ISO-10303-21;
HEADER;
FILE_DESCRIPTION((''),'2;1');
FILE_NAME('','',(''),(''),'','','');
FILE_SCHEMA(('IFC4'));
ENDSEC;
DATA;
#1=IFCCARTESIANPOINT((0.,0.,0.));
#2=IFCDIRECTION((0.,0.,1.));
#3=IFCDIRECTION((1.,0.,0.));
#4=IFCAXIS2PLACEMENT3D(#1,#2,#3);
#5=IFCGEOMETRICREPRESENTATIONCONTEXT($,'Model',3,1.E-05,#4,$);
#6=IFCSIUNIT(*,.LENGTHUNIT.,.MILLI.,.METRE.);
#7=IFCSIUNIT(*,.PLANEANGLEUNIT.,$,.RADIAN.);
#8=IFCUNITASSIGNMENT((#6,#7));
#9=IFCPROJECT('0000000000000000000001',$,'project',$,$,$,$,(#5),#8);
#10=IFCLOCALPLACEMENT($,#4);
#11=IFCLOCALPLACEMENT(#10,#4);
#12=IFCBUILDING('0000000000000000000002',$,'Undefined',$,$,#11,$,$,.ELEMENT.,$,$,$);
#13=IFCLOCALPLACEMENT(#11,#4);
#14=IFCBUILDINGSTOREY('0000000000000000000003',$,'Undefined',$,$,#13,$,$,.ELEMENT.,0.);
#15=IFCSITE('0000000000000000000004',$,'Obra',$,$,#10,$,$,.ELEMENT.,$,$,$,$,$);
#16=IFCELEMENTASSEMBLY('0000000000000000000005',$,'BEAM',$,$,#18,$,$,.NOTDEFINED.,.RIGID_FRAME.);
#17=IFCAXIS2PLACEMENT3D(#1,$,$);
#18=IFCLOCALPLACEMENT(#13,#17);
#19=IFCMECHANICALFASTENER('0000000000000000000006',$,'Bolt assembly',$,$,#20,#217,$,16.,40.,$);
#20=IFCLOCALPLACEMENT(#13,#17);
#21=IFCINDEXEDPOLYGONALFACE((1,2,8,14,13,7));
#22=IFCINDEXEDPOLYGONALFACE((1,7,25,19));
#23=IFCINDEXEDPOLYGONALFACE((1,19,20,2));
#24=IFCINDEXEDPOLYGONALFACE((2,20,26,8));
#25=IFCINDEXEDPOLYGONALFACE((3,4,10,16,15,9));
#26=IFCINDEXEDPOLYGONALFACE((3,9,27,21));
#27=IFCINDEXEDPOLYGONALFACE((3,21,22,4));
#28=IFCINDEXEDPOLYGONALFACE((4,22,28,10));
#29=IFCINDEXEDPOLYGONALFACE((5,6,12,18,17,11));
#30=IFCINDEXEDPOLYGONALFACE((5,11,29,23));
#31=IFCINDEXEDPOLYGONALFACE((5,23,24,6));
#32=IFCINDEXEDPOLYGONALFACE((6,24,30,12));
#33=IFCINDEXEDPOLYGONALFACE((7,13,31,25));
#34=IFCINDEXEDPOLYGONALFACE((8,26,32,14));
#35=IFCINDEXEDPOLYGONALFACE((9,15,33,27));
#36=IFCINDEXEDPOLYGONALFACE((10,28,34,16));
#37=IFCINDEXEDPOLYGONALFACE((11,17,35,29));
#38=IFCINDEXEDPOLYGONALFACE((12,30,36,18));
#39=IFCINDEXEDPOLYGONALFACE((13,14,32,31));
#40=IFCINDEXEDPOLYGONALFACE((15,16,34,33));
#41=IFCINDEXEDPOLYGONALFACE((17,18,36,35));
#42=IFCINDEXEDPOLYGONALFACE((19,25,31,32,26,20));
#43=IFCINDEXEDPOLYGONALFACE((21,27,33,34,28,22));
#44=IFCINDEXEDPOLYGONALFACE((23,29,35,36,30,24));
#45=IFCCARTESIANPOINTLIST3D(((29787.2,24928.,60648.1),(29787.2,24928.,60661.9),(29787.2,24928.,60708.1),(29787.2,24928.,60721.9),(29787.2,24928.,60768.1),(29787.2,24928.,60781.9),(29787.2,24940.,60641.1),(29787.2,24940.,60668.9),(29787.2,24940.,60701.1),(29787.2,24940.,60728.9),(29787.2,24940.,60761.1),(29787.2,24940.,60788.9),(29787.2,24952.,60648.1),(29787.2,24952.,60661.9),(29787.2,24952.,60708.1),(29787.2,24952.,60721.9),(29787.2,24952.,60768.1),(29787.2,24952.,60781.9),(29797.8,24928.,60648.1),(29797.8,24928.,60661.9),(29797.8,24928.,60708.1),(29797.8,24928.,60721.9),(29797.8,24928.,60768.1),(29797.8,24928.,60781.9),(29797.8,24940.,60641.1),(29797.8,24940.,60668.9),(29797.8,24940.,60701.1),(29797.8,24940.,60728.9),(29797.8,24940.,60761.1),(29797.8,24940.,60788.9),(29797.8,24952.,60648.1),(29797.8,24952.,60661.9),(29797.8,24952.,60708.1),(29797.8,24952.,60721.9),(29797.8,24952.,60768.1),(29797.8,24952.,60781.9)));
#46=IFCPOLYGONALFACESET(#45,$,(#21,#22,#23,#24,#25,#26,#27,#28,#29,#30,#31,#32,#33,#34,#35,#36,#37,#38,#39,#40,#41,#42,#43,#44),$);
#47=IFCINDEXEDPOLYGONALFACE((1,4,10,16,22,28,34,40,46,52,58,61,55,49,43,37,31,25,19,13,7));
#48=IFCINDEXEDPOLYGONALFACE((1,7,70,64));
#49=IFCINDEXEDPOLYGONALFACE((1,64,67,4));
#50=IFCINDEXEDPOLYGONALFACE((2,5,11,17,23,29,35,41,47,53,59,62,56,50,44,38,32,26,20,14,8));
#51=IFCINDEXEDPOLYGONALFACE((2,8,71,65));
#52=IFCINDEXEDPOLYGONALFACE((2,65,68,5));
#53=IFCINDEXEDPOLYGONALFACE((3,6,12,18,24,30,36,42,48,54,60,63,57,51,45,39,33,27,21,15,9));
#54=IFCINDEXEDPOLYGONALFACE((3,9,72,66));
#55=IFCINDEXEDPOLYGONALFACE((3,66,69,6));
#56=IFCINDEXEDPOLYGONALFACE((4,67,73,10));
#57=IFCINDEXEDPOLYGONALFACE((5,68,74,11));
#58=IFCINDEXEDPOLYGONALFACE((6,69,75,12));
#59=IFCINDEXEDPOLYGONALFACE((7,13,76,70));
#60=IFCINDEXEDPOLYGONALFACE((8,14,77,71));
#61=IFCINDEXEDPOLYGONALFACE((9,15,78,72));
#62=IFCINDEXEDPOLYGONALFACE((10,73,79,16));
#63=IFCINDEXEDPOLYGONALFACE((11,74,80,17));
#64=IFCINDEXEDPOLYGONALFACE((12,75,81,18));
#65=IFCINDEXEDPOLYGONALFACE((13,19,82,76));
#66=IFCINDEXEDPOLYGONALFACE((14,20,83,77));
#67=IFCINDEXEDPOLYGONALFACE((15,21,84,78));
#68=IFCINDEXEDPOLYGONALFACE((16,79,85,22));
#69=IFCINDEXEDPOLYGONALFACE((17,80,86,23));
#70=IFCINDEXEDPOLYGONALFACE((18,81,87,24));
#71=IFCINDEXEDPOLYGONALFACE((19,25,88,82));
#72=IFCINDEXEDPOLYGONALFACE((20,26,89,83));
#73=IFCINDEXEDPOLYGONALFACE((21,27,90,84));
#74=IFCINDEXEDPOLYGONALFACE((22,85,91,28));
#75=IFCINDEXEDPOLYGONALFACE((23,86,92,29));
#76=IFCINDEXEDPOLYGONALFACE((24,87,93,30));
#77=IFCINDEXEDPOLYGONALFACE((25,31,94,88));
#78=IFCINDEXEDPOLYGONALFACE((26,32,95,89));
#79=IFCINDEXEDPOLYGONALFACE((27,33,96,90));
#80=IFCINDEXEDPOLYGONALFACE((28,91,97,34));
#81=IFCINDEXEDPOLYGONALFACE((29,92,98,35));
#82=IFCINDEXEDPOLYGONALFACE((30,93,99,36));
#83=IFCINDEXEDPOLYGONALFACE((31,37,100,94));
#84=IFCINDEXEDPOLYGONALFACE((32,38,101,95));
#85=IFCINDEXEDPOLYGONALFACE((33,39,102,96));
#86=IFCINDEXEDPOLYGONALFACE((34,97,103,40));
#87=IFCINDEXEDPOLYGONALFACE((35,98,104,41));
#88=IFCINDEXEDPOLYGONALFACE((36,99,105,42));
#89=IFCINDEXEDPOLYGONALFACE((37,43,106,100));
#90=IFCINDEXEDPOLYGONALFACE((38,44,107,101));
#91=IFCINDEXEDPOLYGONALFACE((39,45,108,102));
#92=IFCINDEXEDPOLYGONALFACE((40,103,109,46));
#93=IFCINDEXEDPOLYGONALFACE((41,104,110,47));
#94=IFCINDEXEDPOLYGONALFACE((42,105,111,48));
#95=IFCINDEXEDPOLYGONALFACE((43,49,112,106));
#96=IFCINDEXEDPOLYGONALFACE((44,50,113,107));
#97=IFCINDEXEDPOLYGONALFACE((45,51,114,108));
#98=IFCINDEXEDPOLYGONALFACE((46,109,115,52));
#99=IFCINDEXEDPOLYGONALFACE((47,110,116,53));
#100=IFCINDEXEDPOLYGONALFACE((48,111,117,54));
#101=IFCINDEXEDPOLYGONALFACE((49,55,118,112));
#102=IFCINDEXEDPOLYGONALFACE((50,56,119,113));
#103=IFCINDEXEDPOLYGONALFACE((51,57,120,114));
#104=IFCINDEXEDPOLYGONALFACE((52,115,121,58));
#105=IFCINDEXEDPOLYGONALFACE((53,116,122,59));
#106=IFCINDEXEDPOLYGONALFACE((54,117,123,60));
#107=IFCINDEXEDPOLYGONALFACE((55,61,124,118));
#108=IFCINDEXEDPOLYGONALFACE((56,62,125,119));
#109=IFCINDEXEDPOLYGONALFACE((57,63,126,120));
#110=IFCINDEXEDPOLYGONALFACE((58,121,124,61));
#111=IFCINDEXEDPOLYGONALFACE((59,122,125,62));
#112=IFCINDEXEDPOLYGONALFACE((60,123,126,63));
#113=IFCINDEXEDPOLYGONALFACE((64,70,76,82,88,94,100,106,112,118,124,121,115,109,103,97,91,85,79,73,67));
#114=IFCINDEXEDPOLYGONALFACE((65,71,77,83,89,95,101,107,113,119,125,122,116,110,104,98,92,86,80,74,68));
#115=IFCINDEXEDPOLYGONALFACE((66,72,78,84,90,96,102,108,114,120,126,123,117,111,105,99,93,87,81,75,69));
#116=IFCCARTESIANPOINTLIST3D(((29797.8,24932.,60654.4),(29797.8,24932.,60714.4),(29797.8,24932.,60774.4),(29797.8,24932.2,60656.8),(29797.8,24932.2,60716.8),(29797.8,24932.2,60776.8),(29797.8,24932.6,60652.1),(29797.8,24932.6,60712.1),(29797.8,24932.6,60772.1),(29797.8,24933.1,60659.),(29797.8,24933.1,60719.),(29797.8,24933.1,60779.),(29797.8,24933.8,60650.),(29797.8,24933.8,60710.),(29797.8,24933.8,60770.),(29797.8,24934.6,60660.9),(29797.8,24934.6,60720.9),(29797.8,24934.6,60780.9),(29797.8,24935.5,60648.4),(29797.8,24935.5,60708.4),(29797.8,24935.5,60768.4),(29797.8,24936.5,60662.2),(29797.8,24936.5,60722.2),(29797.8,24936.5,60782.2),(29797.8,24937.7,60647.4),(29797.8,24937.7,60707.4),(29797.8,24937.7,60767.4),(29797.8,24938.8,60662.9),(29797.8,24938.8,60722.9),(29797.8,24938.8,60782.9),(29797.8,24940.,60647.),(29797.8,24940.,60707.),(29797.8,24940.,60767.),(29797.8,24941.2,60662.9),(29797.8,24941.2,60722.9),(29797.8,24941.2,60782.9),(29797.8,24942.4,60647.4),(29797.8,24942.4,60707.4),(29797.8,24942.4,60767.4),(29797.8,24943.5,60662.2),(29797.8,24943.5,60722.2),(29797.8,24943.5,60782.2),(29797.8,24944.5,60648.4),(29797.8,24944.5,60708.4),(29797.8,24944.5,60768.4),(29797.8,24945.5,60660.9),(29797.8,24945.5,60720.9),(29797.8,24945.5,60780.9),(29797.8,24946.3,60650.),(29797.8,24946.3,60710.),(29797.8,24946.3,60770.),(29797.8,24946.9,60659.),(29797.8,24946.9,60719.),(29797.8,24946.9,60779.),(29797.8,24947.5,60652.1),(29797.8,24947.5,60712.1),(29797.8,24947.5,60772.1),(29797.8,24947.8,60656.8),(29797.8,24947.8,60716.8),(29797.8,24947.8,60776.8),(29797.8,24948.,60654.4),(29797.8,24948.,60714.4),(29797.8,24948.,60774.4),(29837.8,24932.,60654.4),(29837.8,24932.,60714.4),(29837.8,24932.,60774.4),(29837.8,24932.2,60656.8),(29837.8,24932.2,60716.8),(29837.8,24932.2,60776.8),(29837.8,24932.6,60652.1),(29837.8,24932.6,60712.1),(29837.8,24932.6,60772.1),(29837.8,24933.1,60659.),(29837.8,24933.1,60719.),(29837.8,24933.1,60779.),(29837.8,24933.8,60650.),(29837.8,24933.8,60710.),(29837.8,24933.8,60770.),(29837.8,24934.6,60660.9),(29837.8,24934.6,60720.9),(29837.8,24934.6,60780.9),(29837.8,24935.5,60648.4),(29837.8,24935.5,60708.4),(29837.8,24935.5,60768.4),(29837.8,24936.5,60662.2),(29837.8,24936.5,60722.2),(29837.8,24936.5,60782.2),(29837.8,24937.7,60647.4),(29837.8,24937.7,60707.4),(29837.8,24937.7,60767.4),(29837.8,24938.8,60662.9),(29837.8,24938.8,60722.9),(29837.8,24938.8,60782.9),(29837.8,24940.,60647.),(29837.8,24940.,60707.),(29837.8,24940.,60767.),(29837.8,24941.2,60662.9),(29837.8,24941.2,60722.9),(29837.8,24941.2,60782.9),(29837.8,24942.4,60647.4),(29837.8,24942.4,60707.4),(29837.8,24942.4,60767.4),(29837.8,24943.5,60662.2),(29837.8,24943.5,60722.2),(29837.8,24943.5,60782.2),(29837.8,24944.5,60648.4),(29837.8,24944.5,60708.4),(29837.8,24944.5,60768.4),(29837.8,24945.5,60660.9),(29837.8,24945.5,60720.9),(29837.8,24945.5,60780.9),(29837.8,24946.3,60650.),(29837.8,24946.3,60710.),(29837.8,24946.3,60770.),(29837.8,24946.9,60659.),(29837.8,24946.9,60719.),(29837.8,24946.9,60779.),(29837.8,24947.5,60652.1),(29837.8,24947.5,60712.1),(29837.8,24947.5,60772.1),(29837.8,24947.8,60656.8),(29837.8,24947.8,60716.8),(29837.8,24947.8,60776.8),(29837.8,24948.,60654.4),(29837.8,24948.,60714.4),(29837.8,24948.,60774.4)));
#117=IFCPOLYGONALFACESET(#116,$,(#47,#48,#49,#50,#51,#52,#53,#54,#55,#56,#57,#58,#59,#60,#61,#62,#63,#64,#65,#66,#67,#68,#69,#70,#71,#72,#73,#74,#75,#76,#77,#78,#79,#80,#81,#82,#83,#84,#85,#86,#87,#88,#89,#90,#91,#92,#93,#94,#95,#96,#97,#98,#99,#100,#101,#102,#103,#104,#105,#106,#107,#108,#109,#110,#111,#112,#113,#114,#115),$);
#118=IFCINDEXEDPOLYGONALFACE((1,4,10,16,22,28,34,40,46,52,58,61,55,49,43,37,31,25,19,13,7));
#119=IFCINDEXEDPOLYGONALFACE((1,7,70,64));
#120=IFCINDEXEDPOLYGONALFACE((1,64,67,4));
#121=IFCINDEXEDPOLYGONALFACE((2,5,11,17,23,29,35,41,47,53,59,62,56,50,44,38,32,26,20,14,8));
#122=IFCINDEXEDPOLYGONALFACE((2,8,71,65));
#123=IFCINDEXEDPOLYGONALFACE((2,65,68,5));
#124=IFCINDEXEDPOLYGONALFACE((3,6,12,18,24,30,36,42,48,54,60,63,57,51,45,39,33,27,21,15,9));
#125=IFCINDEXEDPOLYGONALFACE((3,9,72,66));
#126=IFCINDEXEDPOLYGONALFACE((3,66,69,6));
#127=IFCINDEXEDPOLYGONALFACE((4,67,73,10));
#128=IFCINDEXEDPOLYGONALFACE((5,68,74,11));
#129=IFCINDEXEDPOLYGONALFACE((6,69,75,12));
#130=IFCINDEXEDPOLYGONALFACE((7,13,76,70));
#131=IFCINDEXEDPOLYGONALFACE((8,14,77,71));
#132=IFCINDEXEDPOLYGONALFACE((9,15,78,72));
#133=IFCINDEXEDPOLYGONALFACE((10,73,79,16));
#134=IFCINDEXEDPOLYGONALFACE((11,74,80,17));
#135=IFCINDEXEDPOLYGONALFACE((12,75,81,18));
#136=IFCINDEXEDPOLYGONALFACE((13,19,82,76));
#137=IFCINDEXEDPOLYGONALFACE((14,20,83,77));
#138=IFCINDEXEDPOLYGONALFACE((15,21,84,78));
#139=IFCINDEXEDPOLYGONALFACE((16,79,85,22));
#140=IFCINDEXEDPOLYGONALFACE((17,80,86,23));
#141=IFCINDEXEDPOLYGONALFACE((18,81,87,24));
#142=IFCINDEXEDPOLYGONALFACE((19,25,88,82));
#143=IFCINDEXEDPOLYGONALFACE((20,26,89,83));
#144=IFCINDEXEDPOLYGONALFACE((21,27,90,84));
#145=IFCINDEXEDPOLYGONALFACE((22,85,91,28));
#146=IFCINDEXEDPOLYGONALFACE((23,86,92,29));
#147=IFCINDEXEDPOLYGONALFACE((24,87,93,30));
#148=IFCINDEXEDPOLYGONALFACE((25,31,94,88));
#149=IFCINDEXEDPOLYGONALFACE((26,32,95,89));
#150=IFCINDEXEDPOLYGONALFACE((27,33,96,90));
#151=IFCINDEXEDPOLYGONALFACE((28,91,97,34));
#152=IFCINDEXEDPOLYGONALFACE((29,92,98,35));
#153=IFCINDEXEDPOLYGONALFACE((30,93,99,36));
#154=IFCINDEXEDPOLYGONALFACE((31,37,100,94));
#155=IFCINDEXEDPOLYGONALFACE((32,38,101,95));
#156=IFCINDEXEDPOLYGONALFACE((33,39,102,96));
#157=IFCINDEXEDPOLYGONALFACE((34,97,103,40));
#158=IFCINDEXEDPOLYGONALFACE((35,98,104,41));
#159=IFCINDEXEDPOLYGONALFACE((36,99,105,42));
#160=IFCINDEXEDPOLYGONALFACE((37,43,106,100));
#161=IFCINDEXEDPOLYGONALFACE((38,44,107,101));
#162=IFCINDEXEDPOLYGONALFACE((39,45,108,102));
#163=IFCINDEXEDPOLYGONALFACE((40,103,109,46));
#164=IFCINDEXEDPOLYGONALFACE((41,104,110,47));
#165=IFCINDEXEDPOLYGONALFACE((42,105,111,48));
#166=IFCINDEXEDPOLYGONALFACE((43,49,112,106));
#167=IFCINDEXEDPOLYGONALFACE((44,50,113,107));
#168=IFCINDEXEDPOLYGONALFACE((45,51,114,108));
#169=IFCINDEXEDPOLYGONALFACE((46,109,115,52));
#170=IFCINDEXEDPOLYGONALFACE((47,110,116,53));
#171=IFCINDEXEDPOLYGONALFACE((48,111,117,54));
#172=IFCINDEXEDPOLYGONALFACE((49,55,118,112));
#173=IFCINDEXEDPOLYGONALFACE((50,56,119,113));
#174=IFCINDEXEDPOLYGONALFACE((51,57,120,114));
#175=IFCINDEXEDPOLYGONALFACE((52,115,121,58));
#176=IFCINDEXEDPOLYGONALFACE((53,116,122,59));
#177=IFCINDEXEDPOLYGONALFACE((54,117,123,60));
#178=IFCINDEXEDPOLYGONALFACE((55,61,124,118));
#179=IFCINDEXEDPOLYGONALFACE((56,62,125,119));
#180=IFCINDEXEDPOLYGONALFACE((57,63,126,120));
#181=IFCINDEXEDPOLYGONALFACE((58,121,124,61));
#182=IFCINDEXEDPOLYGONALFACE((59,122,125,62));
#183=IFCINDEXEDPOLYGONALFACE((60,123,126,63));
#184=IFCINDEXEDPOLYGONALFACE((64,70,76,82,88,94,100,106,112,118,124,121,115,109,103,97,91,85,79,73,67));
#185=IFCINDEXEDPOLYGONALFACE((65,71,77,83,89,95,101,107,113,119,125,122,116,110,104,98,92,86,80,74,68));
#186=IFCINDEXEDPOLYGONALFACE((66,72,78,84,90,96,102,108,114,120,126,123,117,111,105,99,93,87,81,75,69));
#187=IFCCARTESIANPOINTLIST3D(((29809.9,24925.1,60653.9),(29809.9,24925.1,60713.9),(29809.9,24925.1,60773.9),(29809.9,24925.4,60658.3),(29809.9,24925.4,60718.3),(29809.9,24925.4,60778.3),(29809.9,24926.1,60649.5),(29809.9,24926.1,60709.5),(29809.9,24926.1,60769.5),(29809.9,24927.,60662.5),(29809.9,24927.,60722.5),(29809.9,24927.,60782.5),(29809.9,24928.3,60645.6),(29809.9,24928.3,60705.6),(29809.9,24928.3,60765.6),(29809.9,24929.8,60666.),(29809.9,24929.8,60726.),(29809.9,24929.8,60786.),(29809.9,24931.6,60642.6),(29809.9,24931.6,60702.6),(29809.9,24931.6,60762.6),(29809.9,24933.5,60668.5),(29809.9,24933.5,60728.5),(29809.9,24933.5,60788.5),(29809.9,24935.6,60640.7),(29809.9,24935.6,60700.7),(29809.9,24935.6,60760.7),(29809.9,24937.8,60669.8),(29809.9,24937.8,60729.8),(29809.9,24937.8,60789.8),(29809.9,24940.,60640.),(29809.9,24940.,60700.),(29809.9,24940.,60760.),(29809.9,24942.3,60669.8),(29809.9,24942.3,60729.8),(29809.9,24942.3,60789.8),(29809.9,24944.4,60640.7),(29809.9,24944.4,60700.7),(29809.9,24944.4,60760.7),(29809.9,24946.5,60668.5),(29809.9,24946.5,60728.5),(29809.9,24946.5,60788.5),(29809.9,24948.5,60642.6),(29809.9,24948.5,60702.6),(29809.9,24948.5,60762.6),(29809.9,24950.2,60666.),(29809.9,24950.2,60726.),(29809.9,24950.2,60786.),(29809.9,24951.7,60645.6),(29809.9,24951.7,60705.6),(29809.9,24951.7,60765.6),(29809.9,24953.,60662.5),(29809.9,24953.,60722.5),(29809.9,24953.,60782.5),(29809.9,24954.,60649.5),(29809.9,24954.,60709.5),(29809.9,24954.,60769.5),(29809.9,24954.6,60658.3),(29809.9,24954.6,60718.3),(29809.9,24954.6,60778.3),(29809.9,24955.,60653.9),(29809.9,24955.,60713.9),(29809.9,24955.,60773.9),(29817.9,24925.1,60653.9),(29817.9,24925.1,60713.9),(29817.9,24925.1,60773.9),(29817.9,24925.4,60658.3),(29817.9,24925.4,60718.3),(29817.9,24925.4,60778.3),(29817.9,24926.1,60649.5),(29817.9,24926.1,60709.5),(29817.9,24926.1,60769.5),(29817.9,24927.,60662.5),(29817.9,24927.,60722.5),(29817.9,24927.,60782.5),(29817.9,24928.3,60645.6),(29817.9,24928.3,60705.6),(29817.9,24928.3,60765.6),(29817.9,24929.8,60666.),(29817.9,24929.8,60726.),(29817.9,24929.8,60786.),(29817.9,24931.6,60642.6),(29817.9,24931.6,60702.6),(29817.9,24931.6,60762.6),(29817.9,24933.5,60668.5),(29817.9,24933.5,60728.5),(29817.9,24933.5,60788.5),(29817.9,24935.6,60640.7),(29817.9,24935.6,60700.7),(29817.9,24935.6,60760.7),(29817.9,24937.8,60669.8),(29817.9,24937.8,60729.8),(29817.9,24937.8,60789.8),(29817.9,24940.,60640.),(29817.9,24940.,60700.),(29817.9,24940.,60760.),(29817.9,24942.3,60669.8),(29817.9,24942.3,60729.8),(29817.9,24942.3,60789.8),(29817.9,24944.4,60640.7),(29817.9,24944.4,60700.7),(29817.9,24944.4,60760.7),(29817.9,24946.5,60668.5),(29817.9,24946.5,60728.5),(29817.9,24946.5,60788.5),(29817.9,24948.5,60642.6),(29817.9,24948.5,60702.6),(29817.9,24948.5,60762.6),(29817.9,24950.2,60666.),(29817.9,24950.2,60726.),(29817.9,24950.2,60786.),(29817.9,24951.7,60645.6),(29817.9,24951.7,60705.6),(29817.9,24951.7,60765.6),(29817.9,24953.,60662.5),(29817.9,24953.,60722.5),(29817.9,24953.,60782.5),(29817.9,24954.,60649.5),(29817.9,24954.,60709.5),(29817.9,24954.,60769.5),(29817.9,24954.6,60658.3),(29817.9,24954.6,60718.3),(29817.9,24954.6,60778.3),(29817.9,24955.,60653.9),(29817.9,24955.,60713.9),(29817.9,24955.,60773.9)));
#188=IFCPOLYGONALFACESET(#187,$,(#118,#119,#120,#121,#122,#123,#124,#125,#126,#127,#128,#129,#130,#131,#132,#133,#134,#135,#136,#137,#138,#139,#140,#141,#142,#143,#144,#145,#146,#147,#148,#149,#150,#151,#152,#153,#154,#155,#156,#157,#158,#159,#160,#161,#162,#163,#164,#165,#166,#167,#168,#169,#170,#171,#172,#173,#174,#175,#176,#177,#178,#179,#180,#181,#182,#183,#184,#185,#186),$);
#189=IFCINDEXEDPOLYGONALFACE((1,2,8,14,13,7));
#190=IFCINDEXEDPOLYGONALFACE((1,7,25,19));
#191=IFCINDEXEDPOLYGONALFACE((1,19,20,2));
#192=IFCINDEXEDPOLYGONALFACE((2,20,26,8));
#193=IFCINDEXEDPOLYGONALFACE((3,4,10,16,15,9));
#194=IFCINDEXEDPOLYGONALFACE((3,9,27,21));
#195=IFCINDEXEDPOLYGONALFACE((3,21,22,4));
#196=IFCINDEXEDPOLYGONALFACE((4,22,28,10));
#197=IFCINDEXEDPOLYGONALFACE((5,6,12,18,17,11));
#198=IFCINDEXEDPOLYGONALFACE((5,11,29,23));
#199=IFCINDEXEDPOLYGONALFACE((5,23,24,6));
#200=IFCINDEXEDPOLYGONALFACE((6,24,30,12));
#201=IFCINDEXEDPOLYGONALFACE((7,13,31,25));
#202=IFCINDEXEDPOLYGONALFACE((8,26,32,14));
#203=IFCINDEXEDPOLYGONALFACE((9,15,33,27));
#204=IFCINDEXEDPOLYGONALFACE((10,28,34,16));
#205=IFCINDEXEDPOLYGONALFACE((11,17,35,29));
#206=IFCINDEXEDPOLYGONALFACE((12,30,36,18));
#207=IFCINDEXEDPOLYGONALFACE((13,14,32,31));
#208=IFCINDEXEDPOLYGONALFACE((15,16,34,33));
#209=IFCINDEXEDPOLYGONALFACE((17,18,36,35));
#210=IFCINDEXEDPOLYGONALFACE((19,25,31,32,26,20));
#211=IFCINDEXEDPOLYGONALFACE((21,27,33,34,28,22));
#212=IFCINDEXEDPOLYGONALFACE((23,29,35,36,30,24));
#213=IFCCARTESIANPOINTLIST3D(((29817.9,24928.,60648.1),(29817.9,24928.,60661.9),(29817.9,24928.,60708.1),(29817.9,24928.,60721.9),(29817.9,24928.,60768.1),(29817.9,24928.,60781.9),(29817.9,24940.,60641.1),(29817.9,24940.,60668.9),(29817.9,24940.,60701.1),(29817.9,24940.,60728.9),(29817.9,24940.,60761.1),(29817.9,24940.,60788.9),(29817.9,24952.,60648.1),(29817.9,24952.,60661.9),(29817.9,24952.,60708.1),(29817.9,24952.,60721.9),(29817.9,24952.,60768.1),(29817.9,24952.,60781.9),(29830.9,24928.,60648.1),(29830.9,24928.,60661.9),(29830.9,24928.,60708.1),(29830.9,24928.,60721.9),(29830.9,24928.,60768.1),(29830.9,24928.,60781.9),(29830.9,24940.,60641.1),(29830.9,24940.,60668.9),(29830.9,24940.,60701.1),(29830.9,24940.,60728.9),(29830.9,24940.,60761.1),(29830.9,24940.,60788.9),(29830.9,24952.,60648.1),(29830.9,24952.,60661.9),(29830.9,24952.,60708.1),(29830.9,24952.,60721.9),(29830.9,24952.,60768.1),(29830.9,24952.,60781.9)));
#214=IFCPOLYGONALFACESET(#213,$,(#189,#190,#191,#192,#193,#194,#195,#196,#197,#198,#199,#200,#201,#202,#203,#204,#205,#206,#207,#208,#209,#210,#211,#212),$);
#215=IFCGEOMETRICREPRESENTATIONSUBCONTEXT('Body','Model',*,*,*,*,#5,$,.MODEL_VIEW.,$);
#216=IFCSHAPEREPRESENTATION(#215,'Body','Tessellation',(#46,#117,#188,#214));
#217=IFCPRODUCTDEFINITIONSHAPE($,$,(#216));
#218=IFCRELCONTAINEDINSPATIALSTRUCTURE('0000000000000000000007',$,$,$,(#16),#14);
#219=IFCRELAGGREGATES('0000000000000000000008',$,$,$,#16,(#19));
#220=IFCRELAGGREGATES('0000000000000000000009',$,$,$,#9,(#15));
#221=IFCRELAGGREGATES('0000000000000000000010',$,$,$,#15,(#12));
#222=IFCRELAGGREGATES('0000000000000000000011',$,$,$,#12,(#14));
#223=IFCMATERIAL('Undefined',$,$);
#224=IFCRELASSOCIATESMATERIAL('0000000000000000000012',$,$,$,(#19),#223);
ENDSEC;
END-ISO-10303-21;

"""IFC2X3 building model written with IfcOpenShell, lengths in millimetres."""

from ifc_helpers import new_model, si_unit, frame, origin_with_axes, origin_2d_with_axis, place, context, subcontext, project, spatial, polyline, circle, outline, extrude, source, transform, mapped, material, element, aggregate, save


model = new_model("IFC2X3")

# Units and contexts
model_context = context("Model", 3, precision=1e-05, world=origin_with_axes())
body_context = subcontext(model_context, "Body", "Model", "MODEL_VIEW")
ifc_project = project(units=[si_unit("LENGTHUNIT", "METRE", prefix="MILLI"), si_unit("PLANEANGLEUNIT", "RADIAN")], contexts=[model_context])

# Site, building, storey
site_placement = place(None, origin_with_axes())
site = spatial("IfcSite", under=ifc_project, at=site_placement, Name="Obra", CompositionType="ELEMENT")
building_placement = place(site_placement, origin_with_axes())
building = spatial("IfcBuilding", under=site, at=building_placement, Name="Undefined", CompositionType="ELEMENT")
storey_placement = place(building_placement, origin_with_axes())
storey = spatial("IfcBuildingStorey", under=building, at=storey_placement, Name="Undefined", CompositionType="ELEMENT", Elevation=0.0)

# Element assembly
assembly_1_placement = place(storey_placement, origin_with_axes())
assembly_1 = element("IfcElementAssembly", 1, at=assembly_1_placement, inside=storey, Name="BEAM", AssemblyPlace="NOTDEFINED", PredefinedType="RIGID_FRAME")
ifc_material_1 = material(Name="Undefined")

# Mechanical fastener
shared_shape_1 = source(origin_with_axes(), body_context, "Body", "SweptSolid", [
    extrude(outline(polyline([(13.9, 0.0), (6.9, 12.0), (-6.9, 12.0), (-13.9, 0.0), (-6.9, -12.0), (6.9, -12.0), (13.9, 0.0)])), frame((0.0, -19.7, 0.0), z_axis=(0.0, 1.0, 0.0), x_axis=(1.0, 0.0, 0.0)), (0.0, 0.0, 1.0), 10.6),
    extrude(circle(Radius=8.0, at=origin_2d_with_axis()), frame((0.0, -9.1, 0.0), z_axis=(0.0, 1.0, 0.0), x_axis=(1.0, 0.0, 0.0)), (0.0, 0.0, 1.0), 40.0),
    extrude(circle(Radius=15.0, at=origin_2d_with_axis()), frame((0.0, 3.0, 0.0), z_axis=(0.0, 1.0, 0.0), x_axis=(1.0, 0.0, 0.0)), (0.0, 0.0, 1.0), 8.0),
    extrude(outline(polyline([(13.9, 0.0), (6.9, 12.0), (-6.9, 12.0), (-13.9, 0.0), (-6.9, -12.0), (6.9, -12.0), (13.9, 0.0)])), frame((0.0, 11.0, 0.0), z_axis=(0.0, 1.0, 0.0), x_axis=(1.0, 0.0, 0.0)), (0.0, 0.0, 1.0), 13.0),
])
mechanical_fastener_1_placement = place(assembly_1_placement, frame((29806.9, 24990.0, 60835.0), z_axis=(0.000002, -1.0, 0.0), x_axis=(0.0, 0.0, -1.0)))
mechanical_fastener_1 = element("IfcMechanicalFastener", 2, at=mechanical_fastener_1_placement, material=ifc_material_1, Name="Bolt assembly", NominalDiameter=16.0, NominalLength=40.0, context=body_context, shape_type="MappedRepresentation", body=[
    mapped(shared_shape_1, transform((60.0, 0.0, 50.0))),
    mapped(shared_shape_1, transform((120.0, 0.0, 50.0))),
    mapped(shared_shape_1, transform((180.0, 0.0, 50.0))),
])
aggregate(assembly_1, [mechanical_fastener_1])

save(model, "model.ifc")
